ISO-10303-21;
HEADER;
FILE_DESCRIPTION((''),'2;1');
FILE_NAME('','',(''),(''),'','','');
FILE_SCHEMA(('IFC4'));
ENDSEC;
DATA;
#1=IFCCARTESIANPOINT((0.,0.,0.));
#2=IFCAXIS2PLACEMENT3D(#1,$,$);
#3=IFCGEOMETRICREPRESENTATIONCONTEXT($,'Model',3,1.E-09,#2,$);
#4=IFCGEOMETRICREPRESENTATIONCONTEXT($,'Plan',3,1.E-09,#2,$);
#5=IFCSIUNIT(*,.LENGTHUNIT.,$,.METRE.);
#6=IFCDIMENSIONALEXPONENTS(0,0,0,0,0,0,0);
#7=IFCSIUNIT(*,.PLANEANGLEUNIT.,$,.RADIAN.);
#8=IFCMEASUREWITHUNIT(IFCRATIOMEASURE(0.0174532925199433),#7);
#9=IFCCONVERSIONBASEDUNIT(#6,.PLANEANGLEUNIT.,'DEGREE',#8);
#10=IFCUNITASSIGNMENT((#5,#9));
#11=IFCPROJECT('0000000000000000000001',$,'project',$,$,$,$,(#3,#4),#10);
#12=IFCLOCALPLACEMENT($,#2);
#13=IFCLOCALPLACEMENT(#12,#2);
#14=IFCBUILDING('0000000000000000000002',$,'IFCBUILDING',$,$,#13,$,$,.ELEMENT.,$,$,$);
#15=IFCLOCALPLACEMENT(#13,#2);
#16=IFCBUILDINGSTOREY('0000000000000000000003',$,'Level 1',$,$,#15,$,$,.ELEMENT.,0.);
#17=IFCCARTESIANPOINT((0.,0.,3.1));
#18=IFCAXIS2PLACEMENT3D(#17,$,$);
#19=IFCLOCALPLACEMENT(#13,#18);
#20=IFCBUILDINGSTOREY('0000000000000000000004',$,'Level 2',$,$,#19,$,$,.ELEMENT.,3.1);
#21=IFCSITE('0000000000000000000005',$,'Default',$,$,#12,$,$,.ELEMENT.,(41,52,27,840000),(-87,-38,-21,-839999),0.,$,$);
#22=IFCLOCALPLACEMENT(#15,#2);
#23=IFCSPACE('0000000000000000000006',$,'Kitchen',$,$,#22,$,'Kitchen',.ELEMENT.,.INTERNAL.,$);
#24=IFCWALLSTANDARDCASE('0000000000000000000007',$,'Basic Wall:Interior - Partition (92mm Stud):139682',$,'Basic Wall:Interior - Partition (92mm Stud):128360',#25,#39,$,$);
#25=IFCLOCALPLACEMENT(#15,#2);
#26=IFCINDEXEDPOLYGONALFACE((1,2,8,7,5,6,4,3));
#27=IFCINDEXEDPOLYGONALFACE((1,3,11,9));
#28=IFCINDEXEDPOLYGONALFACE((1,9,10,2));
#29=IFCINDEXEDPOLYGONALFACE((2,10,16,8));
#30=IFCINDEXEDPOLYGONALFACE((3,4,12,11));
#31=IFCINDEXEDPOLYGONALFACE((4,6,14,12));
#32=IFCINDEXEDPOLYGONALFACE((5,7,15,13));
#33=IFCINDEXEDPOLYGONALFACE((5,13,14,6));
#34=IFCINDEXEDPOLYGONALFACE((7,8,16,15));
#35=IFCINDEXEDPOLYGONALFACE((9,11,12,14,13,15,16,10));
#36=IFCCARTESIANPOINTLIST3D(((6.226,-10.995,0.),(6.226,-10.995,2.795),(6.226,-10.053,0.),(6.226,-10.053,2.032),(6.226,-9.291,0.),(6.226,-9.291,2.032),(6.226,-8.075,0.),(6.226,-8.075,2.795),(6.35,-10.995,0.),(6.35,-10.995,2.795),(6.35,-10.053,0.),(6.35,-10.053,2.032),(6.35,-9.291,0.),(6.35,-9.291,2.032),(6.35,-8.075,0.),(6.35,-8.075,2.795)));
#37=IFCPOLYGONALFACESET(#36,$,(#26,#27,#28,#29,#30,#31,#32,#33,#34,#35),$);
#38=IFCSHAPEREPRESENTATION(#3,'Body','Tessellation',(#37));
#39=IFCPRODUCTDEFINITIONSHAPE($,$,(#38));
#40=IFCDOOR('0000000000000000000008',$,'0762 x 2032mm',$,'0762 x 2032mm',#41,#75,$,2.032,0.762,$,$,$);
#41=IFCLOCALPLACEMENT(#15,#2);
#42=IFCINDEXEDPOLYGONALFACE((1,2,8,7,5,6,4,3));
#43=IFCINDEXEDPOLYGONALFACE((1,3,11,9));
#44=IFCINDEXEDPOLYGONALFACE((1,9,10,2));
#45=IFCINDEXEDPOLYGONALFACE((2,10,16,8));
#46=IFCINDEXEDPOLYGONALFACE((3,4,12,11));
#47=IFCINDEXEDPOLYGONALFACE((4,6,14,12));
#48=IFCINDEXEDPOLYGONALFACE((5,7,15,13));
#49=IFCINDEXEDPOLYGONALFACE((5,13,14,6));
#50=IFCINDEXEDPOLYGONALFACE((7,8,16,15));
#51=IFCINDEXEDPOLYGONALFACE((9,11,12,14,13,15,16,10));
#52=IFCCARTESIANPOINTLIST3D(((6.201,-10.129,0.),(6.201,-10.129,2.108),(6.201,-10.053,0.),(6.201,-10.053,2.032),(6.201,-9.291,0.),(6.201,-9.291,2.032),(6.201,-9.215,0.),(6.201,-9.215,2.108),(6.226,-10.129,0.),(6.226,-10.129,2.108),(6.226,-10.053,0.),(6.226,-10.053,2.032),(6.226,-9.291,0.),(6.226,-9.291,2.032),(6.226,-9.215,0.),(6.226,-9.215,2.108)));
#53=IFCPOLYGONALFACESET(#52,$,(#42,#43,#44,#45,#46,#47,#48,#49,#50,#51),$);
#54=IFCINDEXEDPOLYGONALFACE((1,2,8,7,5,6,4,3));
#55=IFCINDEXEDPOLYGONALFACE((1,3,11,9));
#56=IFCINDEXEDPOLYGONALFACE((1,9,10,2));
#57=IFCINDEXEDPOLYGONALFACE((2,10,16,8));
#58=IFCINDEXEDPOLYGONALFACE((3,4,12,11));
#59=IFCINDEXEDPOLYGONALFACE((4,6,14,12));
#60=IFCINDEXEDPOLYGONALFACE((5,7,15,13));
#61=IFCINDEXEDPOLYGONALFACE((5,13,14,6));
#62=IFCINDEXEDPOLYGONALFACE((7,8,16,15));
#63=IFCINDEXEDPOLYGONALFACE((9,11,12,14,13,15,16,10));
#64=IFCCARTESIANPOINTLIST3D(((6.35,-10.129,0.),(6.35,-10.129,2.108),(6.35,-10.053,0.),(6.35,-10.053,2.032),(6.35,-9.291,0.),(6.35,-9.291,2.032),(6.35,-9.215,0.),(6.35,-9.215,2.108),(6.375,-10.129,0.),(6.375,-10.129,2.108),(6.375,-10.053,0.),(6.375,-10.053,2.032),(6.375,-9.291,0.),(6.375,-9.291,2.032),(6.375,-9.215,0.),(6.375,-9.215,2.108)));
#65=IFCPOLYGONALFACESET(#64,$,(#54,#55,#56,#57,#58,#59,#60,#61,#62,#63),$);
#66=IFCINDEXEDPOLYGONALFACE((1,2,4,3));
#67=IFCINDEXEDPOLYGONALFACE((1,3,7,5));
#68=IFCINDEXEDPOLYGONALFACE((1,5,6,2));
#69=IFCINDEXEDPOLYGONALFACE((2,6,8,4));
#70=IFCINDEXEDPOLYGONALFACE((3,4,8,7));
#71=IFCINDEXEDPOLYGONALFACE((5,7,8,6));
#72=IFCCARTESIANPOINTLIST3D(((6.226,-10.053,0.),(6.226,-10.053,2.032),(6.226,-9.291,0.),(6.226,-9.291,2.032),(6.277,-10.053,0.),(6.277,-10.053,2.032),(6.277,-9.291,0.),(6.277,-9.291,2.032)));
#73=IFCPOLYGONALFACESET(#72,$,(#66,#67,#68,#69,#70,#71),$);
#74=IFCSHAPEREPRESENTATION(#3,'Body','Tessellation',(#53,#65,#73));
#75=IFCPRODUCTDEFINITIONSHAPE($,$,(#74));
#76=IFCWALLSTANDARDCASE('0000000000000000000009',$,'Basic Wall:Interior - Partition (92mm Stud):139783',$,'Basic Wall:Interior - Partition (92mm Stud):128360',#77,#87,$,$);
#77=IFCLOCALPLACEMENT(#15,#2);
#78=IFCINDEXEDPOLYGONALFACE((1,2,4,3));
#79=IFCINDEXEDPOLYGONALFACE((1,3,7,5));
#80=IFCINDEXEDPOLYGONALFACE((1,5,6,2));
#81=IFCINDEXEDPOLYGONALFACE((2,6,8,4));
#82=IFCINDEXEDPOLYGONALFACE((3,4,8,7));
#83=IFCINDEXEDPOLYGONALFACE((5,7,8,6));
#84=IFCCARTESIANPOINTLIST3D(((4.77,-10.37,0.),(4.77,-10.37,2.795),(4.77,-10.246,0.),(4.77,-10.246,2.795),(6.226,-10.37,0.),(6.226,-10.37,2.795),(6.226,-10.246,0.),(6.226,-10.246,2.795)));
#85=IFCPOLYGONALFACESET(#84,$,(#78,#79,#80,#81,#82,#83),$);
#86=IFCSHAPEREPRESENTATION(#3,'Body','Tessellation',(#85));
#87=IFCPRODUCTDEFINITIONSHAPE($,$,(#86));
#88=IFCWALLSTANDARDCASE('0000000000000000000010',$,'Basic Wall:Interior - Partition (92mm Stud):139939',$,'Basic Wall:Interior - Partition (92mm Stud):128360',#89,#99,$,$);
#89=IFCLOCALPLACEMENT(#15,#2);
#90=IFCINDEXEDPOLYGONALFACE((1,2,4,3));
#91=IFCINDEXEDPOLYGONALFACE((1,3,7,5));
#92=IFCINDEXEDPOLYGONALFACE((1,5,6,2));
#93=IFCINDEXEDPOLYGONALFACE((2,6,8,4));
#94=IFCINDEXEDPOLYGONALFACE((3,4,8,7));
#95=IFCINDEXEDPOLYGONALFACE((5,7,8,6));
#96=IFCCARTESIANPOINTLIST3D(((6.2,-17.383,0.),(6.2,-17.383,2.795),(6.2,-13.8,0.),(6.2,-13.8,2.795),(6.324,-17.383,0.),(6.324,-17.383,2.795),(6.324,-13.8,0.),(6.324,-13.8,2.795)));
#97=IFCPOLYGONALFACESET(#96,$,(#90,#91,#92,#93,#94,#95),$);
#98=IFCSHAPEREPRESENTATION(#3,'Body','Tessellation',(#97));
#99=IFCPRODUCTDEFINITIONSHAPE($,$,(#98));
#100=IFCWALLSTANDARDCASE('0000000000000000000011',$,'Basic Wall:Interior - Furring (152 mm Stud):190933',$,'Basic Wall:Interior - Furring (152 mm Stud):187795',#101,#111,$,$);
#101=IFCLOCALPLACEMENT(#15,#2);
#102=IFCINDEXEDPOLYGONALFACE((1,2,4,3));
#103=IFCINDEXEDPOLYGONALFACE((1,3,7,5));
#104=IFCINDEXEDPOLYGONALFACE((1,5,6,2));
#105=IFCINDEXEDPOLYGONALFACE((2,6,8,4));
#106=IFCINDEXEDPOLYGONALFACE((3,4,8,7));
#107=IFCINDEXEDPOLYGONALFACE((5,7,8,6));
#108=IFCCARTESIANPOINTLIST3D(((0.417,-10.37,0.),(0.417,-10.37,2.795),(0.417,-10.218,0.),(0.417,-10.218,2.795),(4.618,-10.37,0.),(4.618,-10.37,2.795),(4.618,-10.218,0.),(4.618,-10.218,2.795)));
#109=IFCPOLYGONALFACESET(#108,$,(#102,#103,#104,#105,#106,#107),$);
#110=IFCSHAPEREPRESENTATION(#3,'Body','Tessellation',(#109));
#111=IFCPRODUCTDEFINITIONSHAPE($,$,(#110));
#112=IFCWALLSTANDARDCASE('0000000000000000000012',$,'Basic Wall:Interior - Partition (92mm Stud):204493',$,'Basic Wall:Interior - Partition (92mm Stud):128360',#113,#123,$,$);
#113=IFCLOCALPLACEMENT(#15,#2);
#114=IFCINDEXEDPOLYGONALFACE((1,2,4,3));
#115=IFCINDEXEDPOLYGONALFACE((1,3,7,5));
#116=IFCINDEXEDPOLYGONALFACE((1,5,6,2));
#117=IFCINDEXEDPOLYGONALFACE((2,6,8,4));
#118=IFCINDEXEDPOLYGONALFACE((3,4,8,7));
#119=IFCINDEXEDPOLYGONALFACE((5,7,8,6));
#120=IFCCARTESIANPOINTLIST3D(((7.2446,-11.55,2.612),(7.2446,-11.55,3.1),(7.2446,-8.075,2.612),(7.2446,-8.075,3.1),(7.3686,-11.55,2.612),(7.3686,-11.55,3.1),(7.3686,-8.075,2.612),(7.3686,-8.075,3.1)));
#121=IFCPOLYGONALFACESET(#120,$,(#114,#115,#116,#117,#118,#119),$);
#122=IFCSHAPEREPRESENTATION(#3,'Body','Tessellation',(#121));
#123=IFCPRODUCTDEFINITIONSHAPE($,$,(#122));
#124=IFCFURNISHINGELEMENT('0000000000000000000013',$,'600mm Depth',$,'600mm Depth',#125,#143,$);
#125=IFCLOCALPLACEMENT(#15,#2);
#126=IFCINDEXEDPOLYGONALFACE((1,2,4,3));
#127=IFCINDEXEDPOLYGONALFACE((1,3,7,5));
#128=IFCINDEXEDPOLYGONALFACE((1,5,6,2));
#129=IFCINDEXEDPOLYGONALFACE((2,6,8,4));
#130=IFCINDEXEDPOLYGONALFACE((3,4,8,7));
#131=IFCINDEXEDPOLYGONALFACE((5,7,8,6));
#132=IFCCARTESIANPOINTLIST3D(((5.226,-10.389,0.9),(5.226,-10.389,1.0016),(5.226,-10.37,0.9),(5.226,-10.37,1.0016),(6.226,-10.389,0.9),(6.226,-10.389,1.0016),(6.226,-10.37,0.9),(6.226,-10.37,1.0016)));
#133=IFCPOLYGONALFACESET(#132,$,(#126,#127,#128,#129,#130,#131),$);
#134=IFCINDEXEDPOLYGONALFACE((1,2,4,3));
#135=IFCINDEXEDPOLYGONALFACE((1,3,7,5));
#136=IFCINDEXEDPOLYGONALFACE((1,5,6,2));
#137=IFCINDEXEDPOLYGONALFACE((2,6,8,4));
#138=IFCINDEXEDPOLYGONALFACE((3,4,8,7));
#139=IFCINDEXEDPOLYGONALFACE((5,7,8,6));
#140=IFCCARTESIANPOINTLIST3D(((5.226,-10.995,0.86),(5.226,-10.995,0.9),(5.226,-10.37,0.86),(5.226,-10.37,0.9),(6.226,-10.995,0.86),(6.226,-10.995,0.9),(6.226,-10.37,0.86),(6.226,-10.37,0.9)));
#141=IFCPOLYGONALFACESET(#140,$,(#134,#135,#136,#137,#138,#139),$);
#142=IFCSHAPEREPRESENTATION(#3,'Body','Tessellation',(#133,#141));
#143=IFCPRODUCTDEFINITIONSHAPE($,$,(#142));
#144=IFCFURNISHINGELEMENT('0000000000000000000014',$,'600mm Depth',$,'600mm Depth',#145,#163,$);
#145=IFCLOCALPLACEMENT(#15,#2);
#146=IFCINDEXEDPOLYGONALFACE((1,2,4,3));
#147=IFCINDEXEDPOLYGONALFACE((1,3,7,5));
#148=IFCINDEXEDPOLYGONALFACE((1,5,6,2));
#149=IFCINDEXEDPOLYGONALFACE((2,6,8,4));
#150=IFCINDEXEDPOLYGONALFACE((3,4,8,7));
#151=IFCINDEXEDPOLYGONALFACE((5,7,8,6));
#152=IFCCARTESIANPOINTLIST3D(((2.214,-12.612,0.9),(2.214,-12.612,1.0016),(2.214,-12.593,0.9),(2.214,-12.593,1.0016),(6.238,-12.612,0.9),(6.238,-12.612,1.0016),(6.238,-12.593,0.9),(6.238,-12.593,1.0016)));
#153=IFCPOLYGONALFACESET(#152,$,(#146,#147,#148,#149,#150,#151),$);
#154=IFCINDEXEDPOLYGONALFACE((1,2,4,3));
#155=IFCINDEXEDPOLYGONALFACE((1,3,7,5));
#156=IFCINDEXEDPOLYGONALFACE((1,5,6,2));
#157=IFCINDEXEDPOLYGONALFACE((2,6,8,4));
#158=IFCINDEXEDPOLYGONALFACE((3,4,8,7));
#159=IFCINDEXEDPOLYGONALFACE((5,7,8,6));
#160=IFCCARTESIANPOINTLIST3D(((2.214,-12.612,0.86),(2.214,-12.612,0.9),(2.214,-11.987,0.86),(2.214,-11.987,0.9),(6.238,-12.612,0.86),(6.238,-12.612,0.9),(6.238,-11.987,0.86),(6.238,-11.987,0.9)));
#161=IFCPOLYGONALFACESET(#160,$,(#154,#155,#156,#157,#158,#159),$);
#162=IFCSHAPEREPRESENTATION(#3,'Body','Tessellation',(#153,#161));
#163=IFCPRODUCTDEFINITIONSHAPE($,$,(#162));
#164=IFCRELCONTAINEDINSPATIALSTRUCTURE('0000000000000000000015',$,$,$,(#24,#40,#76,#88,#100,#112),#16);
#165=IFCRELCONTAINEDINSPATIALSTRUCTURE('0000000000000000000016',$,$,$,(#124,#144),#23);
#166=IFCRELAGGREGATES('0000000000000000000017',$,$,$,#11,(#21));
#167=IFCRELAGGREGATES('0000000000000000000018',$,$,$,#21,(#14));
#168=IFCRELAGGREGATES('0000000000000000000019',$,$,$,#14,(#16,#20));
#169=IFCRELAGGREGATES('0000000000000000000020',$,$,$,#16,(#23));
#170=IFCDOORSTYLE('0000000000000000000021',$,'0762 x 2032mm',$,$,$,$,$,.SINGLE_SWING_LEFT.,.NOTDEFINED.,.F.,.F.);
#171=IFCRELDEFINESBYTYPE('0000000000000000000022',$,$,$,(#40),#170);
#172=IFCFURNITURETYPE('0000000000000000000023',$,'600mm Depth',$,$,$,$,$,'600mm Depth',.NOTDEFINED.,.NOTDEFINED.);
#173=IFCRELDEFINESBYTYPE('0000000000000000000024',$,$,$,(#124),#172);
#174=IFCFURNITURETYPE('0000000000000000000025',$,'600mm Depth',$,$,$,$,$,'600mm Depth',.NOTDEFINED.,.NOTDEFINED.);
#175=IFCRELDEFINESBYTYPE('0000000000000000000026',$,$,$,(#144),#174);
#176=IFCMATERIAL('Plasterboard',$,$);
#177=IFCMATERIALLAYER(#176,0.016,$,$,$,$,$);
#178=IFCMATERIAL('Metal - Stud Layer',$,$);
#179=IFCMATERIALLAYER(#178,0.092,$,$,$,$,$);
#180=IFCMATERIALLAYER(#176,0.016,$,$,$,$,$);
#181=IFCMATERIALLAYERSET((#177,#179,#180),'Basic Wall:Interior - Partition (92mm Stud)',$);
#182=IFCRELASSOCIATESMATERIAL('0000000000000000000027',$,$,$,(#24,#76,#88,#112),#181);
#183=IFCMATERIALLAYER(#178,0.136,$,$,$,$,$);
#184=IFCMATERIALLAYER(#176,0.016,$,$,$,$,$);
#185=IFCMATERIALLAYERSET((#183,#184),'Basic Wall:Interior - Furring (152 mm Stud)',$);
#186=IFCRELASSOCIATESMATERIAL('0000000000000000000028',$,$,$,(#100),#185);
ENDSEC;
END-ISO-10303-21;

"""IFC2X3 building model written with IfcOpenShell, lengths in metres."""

from ifc_helpers import new_model, entity, si_unit, converted_unit, frame, frame_2d, origin, origin_2d_with_axis, place, context, project, spatial, polyline, rectangle, outline, extrude, source, transform, mapped, material, layer, layer_set, layer_usage, type_object, type_shapes, element, fill, save


model = new_model("IFC2X3")

# Units and contexts
model_context = context("Model", 3, precision=1e-09, world=origin())
plan_context = context("Plan", 3, precision=1e-09, world=origin())
ifc_project = project(units=[si_unit("LENGTHUNIT", "METRE"), converted_unit("PLANEANGLEUNIT", "DEGREE", entity("IfcRatioMeasure", 0.0174532925199433), si_unit("PLANEANGLEUNIT", "RADIAN"), dimensions=[0, 0, 0, 0, 0, 0, 0])], contexts=[model_context, plan_context])

# Site, building, storey
site_placement = place(None, origin())
site = spatial("IfcSite", under=ifc_project, at=site_placement, Name="Default", CompositionType="ELEMENT", RefLatitude=(41, 52, 27, 840000), RefLongitude=(-87, -38, -21, -839999), RefElevation=0.0)
building_placement = place(site_placement, origin())
building = spatial("IfcBuilding", under=site, at=building_placement, Name="IFCBUILDING", CompositionType="ELEMENT")
storey_1_placement = place(building_placement, origin())
storey_1 = spatial("IfcBuildingStorey", under=building, at=storey_1_placement, Name="Level 1", CompositionType="ELEMENT", Elevation=0.0)

# Shared definitions
ifc_material_1 = material(Name="Metal - Stud Layer")
ifc_material_2 = material(Name="Plasterboard")

# Wall, opening, door
ifc_layer_1 = layer(ifc_material_2, 0.016)
ifc_layer_2 = layer(ifc_material_1, 0.092)
ifc_layer_3 = layer(ifc_material_2, 0.016)
ifc_layer_set_1 = layer_set([ifc_layer_1, ifc_layer_2, ifc_layer_3], Name="Basic Wall:Interior - Partition (92mm Stud)")
ifc_layer_usage_1 = layer_usage(ifc_layer_set_1, "AXIS2", "NEGATIVE", 0.062)
wall_1_placement = place(storey_1_placement, frame((6.288, -10.995, 0.0), z_axis=(0.0, 0.0, 1.0), x_axis=(0.0, 1.0, 0.0)))
wall_1 = element("IfcWallStandardCase", 1, at=wall_1_placement, inside=storey_1, material=ifc_layer_usage_1, Name="Basic Wall:Interior - Partition (92mm Stud):139682", ObjectType="Basic Wall:Interior - Partition (92mm Stud):128360", context=model_context, shape_type="SweptSolid", body=[
    extrude(rectangle(XDim=2.92, YDim=0.124, at=frame_2d((1.46, 0.0), x_axis=(-1.0, 0.0))), origin(), (0.0, 0.0, 1.0), 2.795),
])
opening_1_placement = place(wall_1_placement, frame((0.942, -0.062, 0.0)))
opening_1 = element("IfcOpeningElement", 2, at=opening_1_placement, cuts=wall_1, ObjectType="Opening", context=model_context, shape_type="SweptSolid", body=[
    extrude(rectangle(XDim=0.762, YDim=2.032, at=frame_2d((1.016, 0.381), x_axis=(0.0, -1.0))), frame((0.0, 0.0, 0.0), z_axis=(0.0, 1.0, 0.0), x_axis=(0.0, 0.0, 1.0)), (0.0, 0.0, 1.0), 0.124),
])
door_style_1 = type_object("IfcDoorStyle", Name="0762 x 2032mm", ConstructionType="NOTDEFINED", OperationType="SINGLE_SWING_LEFT", ParameterTakesPrecedence=False, Sizeable=False)
shared_shape_1 = source(origin(), model_context, "Body", "SweptSolid", [
    extrude(outline(polyline([(-0.457, -1.073), (0.457, -1.073), (0.457, 1.035), (0.381, 1.035), (0.381, -0.997), (-0.381, -0.997), (-0.381, 1.035), (-0.457, 1.035), (-0.457, -1.073)])), frame((0.381, 0.149, 1.035), z_axis=(0.0, -1.0, 0.0), x_axis=(-1.0, 0.0, 0.0)), (0.0, 0.0, 1.0), 0.025),
    extrude(outline(polyline([(-1.073, -0.457), (1.035, -0.457), (1.035, -0.381), (-0.997, -0.381), (-0.997, 0.381), (1.035, 0.381), (1.035, 0.457), (-1.073, 0.457), (-1.073, -0.457)])), frame((0.381, 0.0, 1.035), z_axis=(0.0, -1.0, 0.0), x_axis=(0.0, 0.0, -1.0)), (0.0, 0.0, 1.0), 0.025),
    extrude(rectangle(XDim=0.762, YDim=0.051, at=origin_2d_with_axis()), frame((0.381, 0.0985, 0.0)), (0.0, 0.0, 1.0), 2.032),
])
type_shapes(door_style_1, [shared_shape_1])
door_1_placement = place(opening_1_placement, origin())
door_1 = element("IfcDoor", 3, at=door_1_placement, inside=storey_1, type_object=door_style_1, Name="0762 x 2032mm", ObjectType="0762 x 2032mm", OverallHeight=2.032, OverallWidth=0.762, context=model_context, shape_type="MappedRepresentation", body=[
    mapped(shared_shape_1, transform((0.0, 0.0, 0.0), scale=1.0)),
])
fill(opening_1, door_1)

# Walls
ifc_layer_usage_2 = layer_usage(ifc_layer_set_1, "AXIS2", "NEGATIVE", 0.062)
wall_2_placement = place(storey_1_placement, frame((4.77, -10.308, 0.0)))
element("IfcWallStandardCase", 4, at=wall_2_placement, inside=storey_1, material=ifc_layer_usage_2, Name="Basic Wall:Interior - Partition (92mm Stud):139783", ObjectType="Basic Wall:Interior - Partition (92mm Stud):128360", context=model_context, shape_type="SweptSolid", body=[
    extrude(rectangle(XDim=1.456, YDim=0.124, at=frame_2d((0.728, 0.0), x_axis=(-1.0, 0.0))), origin(), (0.0, 0.0, 1.0), 2.795),
])
ifc_layer_usage_3 = layer_usage(ifc_layer_set_1, "AXIS2", "NEGATIVE", 0.062)
wall_3_placement = place(storey_1_placement, frame((6.262, -13.8, 0.0), z_axis=(0.0, 0.0, 1.0), x_axis=(0.0, -1.0, 0.0)))
element("IfcWallStandardCase", 5, at=wall_3_placement, inside=storey_1, material=ifc_layer_usage_3, Name="Basic Wall:Interior - Partition (92mm Stud):139939", ObjectType="Basic Wall:Interior - Partition (92mm Stud):128360", context=model_context, shape_type="SweptSolid", body=[
    extrude(rectangle(XDim=3.583, YDim=0.124, at=frame_2d((1.7915, 0.0), x_axis=(-1.0, 0.0))), origin(), (0.0, 0.0, 1.0), 2.795),
])

# Shared definitions
storey_2_placement = place(building_placement, frame((0.0, 0.0, 3.1)))
storey_2 = spatial("IfcBuildingStorey", under=building, at=storey_2_placement, Name="Level 2", CompositionType="ELEMENT", Elevation=3.1)

# Walls
ifc_layer_4 = layer(ifc_material_1, 0.136)
ifc_layer_5 = layer(ifc_material_2, 0.016)
ifc_layer_set_2 = layer_set([ifc_layer_4, ifc_layer_5], Name="Basic Wall:Interior - Furring (152 mm Stud)")
ifc_layer_usage_4 = layer_usage(ifc_layer_set_2, "AXIS2", "NEGATIVE", 0.076)
wall_4_placement = place(storey_1_placement, frame((0.417, -10.294, 0.0)))
element("IfcWallStandardCase", 6, at=wall_4_placement, inside=storey_1, material=ifc_layer_usage_4, Name="Basic Wall:Interior - Furring (152 mm Stud):190933", ObjectType="Basic Wall:Interior - Furring (152 mm Stud):187795", context=model_context, shape_type="SweptSolid", body=[
    extrude(rectangle(XDim=4.201, YDim=0.152, at=frame_2d((2.1005, 0.0), x_axis=(-1.0, 0.0))), origin(), (0.0, 0.0, 1.0), 2.795),
])
ifc_layer_usage_5 = layer_usage(ifc_layer_set_1, "AXIS2", "NEGATIVE", 0.062)
wall_5_placement = place(storey_1_placement, frame((7.3066, -11.55, 2.612), z_axis=(0.0, 0.0, 1.0), x_axis=(0.0, 1.0, 0.0)))
element("IfcWallStandardCase", 7, at=wall_5_placement, inside=storey_1, material=ifc_layer_usage_5, Name="Basic Wall:Interior - Partition (92mm Stud):204493", ObjectType="Basic Wall:Interior - Partition (92mm Stud):128360", context=model_context, shape_type="SweptSolid", body=[
    extrude(rectangle(XDim=3.475, YDim=0.124, at=frame_2d((1.7375, 0.0), x_axis=(-1.0, 0.0))), origin(), (0.0, 0.0, 1.0), 0.488),
])

# Shared definitions
space_1_placement = place(storey_1_placement, origin())
space_1 = spatial("IfcSpace", under=storey_1, at=space_1_placement, Name="Kitchen", LongName="Kitchen", CompositionType="ELEMENT", InteriorOrExteriorSpace="INTERNAL")

# Furnishing elements
furniture_type_1 = type_object("IfcFurnitureType", Name="600mm Depth", ElementType="600mm Depth", AssemblyPlace="NOTDEFINED")
shared_shape_2 = source(origin(), model_context, "Body", "SweptSolid", [
    extrude(rectangle(XDim=0.0191, YDim=1.0, at=origin_2d_with_axis()), frame((-0.7005, -0.0095, 0.9), z_axis=(0.0, 0.0, 1.0), x_axis=(0.0, -1.0, 0.0)), (0.0, 0.0, 1.0), 0.1016),
    extrude(rectangle(XDim=1.0, YDim=0.625, at=origin_2d_with_axis()), frame((-0.7005, -0.3125, 0.86), z_axis=(0.0, 0.0, 1.0), x_axis=(-1.0, 0.0, 0.0)), (0.0, 0.0, 1.0), 0.04),
])
type_shapes(furniture_type_1, [shared_shape_2])
furnishing_1_placement = place(space_1_placement, frame((6.4265, -10.37, 0.0)))
element("IfcFurnishingElement", 8, at=furnishing_1_placement, inside=space_1, type_object=furniture_type_1, Name="600mm Depth", ObjectType="600mm Depth", context=model_context, shape_type="MappedRepresentation", body=[
    mapped(shared_shape_2, transform((0.0, 0.0, 0.0), scale=1.0)),
])
furniture_type_2 = type_object("IfcFurnitureType", Name="600mm Depth", ElementType="600mm Depth", AssemblyPlace="NOTDEFINED")
shared_shape_3 = source(origin(), model_context, "Body", "SweptSolid", [
    extrude(rectangle(XDim=0.0191, YDim=4.024, at=origin_2d_with_axis()), frame((0.8115, -0.0095, 0.9), z_axis=(0.0, 0.0, 1.0), x_axis=(0.0, -1.0, 0.0)), (0.0, 0.0, 1.0), 0.1016),
    extrude(rectangle(XDim=4.024, YDim=0.625, at=origin_2d_with_axis()), frame((0.8115, -0.3125, 0.86), z_axis=(0.0, 0.0, 1.0), x_axis=(-1.0, 0.0, 0.0)), (0.0, 0.0, 1.0), 0.04),
])
type_shapes(furniture_type_2, [shared_shape_3])
furnishing_2_placement = place(space_1_placement, frame((5.0375, -12.612, 0.0), z_axis=(0.0, 0.0, 1.0), x_axis=(-1.0, 0.0, 0.0)))
element("IfcFurnishingElement", 9, at=furnishing_2_placement, inside=space_1, type_object=furniture_type_2, Name="600mm Depth", ObjectType="600mm Depth", context=model_context, shape_type="MappedRepresentation", body=[
    mapped(shared_shape_3, transform((0.0, 0.0, 0.0), scale=1.0)),
])

save(model, "model.ifc")
